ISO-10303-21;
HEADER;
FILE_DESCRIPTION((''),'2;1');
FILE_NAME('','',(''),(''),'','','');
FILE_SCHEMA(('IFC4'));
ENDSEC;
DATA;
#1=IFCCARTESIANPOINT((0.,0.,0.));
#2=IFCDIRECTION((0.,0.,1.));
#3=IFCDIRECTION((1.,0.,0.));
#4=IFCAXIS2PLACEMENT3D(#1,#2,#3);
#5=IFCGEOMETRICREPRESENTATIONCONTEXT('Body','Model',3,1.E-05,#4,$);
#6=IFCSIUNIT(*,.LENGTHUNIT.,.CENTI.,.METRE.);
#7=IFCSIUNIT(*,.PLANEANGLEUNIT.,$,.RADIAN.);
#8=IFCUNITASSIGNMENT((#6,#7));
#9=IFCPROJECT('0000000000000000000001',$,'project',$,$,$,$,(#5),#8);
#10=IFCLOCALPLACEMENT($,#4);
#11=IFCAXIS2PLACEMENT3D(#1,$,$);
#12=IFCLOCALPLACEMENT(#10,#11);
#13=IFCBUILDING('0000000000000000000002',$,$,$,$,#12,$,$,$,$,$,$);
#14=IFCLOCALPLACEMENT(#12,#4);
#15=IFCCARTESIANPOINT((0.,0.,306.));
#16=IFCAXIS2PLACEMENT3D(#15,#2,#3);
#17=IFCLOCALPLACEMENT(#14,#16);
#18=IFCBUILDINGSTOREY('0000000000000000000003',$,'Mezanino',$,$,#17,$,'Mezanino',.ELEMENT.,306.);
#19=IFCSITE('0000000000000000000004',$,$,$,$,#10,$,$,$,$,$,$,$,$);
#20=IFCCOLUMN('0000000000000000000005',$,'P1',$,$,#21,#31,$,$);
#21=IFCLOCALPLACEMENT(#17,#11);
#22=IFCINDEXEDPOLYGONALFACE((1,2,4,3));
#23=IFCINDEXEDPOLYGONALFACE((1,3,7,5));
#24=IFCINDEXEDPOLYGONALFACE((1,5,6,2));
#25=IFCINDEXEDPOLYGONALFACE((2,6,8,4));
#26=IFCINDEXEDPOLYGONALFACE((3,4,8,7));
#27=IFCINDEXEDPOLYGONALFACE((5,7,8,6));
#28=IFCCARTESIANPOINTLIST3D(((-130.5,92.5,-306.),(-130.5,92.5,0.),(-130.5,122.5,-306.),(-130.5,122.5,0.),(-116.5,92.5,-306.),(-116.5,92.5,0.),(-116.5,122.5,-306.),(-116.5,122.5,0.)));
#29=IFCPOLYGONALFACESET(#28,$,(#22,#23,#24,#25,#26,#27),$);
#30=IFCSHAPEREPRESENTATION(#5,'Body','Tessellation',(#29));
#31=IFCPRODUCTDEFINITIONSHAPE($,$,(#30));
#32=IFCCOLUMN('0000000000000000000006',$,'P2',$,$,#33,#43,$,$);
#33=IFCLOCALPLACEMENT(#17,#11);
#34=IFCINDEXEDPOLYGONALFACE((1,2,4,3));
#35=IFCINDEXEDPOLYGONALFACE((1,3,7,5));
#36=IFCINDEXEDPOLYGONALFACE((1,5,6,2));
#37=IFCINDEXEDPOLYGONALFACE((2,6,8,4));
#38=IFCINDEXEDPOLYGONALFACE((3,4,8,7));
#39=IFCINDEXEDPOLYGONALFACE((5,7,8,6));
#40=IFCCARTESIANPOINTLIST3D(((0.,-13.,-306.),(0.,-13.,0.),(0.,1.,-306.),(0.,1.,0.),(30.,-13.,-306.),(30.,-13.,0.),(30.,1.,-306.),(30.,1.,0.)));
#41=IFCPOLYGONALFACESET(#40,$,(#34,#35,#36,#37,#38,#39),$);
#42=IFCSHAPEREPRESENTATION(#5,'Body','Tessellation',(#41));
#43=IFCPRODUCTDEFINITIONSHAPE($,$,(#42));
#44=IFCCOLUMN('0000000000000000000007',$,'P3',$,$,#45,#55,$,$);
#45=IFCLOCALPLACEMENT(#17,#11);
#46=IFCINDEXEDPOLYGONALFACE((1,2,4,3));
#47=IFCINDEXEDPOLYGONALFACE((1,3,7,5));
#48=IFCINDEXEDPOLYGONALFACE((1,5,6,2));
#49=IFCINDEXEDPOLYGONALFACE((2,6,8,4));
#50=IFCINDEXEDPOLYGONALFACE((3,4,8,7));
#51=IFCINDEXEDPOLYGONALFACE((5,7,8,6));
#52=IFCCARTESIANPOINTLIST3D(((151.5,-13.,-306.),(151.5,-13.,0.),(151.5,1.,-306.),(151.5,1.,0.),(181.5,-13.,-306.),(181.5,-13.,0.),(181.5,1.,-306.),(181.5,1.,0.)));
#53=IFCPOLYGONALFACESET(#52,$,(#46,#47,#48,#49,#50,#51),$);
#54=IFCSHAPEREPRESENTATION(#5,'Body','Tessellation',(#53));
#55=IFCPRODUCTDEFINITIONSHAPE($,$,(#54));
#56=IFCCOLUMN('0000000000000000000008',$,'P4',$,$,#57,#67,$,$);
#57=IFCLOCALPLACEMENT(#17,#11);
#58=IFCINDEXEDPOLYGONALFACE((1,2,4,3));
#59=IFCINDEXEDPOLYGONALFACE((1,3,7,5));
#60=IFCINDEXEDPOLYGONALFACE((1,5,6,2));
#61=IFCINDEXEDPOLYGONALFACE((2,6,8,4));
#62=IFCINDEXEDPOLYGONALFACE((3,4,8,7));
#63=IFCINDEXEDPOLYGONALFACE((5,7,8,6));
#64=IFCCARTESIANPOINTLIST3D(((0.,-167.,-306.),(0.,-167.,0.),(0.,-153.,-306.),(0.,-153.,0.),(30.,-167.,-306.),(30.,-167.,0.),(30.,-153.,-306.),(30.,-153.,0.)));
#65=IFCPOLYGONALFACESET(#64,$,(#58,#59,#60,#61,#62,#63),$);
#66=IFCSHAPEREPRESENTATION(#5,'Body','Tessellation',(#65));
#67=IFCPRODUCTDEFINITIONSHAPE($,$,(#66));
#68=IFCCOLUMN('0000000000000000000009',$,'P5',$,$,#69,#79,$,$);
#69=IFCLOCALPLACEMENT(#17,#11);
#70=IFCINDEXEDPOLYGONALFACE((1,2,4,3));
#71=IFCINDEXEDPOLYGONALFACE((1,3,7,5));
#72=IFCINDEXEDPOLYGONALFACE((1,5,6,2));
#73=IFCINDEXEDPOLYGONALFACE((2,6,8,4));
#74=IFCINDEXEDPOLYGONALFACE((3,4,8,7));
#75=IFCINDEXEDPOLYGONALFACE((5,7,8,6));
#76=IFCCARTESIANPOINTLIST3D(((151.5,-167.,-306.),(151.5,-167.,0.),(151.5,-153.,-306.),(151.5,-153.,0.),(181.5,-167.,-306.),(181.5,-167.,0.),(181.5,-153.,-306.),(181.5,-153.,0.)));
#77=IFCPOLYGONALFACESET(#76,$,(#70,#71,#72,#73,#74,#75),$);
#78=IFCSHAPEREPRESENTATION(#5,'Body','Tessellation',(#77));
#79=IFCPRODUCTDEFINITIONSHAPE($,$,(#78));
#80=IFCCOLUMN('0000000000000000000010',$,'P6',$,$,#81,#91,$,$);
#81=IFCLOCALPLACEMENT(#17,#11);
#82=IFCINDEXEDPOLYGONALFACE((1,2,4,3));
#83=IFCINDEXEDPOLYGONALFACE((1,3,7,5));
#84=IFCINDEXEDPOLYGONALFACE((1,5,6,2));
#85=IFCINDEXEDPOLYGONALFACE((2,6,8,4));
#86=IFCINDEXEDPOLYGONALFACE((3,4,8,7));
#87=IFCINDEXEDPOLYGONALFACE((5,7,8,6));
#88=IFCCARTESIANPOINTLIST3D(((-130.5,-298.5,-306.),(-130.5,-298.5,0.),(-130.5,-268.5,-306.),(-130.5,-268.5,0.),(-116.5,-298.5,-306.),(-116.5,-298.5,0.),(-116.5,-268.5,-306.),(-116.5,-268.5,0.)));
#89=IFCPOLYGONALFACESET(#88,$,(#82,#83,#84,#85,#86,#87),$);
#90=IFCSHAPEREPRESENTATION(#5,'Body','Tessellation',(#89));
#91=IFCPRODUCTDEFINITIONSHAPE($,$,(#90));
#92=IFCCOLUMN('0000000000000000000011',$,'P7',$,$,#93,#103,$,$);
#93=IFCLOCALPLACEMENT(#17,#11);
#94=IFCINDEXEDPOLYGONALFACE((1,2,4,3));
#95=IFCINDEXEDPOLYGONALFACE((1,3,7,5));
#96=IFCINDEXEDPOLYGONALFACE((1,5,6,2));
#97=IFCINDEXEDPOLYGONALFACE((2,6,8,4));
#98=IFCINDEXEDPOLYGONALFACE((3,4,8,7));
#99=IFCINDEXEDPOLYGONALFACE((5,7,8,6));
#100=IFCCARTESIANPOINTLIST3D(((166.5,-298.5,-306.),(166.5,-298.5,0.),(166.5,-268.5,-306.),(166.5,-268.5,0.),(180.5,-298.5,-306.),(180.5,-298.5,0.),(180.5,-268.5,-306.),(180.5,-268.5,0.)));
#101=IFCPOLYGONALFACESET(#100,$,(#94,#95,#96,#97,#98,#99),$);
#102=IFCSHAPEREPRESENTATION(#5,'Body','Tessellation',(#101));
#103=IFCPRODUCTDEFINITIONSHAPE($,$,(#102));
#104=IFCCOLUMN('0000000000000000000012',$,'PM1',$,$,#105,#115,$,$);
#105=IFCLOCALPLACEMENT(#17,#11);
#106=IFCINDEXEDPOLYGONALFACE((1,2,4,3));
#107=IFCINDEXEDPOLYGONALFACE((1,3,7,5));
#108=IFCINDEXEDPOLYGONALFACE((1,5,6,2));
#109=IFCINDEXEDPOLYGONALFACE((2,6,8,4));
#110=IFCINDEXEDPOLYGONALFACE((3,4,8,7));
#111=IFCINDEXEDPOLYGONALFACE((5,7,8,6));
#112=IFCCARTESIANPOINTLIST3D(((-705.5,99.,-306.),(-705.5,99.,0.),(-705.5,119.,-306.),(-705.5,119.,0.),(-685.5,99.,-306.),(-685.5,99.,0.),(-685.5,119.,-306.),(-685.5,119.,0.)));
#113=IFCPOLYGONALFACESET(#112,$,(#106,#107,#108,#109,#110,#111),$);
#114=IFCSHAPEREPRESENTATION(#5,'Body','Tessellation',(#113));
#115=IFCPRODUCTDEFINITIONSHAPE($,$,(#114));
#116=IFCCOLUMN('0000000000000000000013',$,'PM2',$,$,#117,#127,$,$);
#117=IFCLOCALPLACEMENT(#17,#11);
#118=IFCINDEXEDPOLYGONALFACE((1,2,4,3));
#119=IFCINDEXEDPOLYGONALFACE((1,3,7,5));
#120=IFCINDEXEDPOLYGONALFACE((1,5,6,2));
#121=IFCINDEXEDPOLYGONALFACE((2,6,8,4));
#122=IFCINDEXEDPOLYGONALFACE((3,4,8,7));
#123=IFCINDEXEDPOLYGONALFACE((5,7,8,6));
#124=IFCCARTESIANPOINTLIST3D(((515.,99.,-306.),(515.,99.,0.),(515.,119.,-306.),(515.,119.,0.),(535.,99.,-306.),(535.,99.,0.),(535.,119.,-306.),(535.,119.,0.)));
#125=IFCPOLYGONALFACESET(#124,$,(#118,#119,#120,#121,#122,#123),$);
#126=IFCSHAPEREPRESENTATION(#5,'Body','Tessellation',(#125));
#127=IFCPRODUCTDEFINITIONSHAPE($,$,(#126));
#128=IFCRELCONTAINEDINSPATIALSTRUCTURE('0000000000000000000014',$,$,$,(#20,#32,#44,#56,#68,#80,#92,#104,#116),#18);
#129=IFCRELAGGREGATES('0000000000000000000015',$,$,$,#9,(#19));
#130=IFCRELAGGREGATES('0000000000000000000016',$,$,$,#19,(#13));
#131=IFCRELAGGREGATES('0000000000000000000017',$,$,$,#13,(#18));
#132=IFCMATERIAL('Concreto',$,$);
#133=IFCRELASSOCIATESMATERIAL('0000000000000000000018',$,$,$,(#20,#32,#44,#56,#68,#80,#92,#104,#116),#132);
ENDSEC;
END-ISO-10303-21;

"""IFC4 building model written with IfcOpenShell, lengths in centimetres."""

from ifc_helpers import new_model, si_unit, frame, origin, origin_with_axes, origin_2d_with_axis, place, context, project, spatial, rectangle, extrude, material, element, save


model = new_model("IFC4")

# Units and contexts
model_context = context("Model", 3, precision=1e-05, world=origin_with_axes(), identifier="Body")
ifc_project = project(units=[si_unit("LENGTHUNIT", "METRE", prefix="CENTI"), si_unit("PLANEANGLEUNIT", "RADIAN")], contexts=[model_context])

# Site, building, storey
site_placement = place(None, origin_with_axes())
site = spatial("IfcSite", under=ifc_project, at=site_placement)
building_placement = place(site_placement, origin())
building = spatial("IfcBuilding", under=site, at=building_placement)
placement = place(building_placement, origin_with_axes())
storey_placement = place(placement, frame((0.0, 0.0, 306.0), z_axis=(0.0, 0.0, 1.0), x_axis=(1.0, 0.0, 0.0)))
storey = spatial("IfcBuildingStorey", under=building, at=storey_placement, Name="Mezanino", LongName="Mezanino", CompositionType="ELEMENT", Elevation=306.0)

# Columns
ifc_material_1 = material(Name="Concreto")
column_placement = place(storey_placement, frame((-123.5, 107.5, 0.0), z_axis=(0.0, 0.0, 1.0), x_axis=(1.0, 0.0, 0.0)))
element("IfcColumn", 1, at=column_placement, inside=storey, material=ifc_material_1, Name="P1", context=model_context, shape_type="SolidModel", body=[
    extrude(rectangle(XDim=14.0, YDim=30.0, at=origin_2d_with_axis()), origin_with_axes(), (0.0, 0.0, -1.0), 306.0),
])
for number, where, z_axis, x_axis, name in (
    (2, (15.0, -6.0, 0.0), (0.0, 0.0, 1.0), (1.0, 0.0, 0.0), "P2"),
    (3, (166.5, -6.0, 0.0), (0.0, 0.0, 1.0), (1.0, 0.0, 0.0), "P3"),
    (4, (15.0, -160.0, 0.0), (0.0, 0.0, 1.0), (1.0, 0.0, 0.0), "P4"),
    (5, (166.5, -160.0, 0.0), (0.0, 0.0, 1.0), (1.0, 0.0, 0.0), "P5"),
):
    element("IfcColumn", number, at=place(storey_placement, frame(where, z_axis=z_axis, x_axis=x_axis)), inside=storey, material=ifc_material_1, Name=name, context=model_context, shape_type="SolidModel", body=[
        extrude(rectangle(XDim=14.0, YDim=30.0, at=origin_2d_with_axis()), frame((0.0, 0.0, 0.0), z_axis=(0.0, 0.0, 1.0), x_axis=(0.0, 1.0, 0.0)), (0.0, 0.0, -1.0), 306.0),
    ])
for number, where, z_axis, x_axis, name in (
    (6, (-123.5, -283.5, 0.0), (0.0, 0.0, 1.0), (1.0, 0.0, 0.0), "P6"),
    (7, (173.5, -283.5, 0.0), (0.0, 0.0, 1.0), (1.0, 0.0, 0.0), "P7"),
):
    element("IfcColumn", number, at=place(storey_placement, frame(where, z_axis=z_axis, x_axis=x_axis)), inside=storey, material=ifc_material_1, Name=name, context=model_context, shape_type="SolidModel", body=[
        extrude(rectangle(XDim=14.0, YDim=30.0, at=origin_2d_with_axis()), origin_with_axes(), (0.0, 0.0, -1.0), 306.0),
    ])
for number, where, z_axis, x_axis, name in (
    (8, (-695.5, 109.0, 0.0), (0.0, 0.0, 1.0), (1.0, 0.0, 0.0), "PM1"),
    (9, (525.0, 109.0, 0.0), (0.0, 0.0, 1.0), (1.0, 0.0, 0.0), "PM2"),
):
    element("IfcColumn", number, at=place(storey_placement, frame(where, z_axis=z_axis, x_axis=x_axis)), inside=storey, material=ifc_material_1, Name=name, context=model_context, shape_type="SolidModel", body=[
        extrude(rectangle(XDim=20.0, YDim=20.0, at=origin_2d_with_axis()), origin_with_axes(), (0.0, 0.0, -1.0), 306.0),
    ])

save(model, "model.ifc")
